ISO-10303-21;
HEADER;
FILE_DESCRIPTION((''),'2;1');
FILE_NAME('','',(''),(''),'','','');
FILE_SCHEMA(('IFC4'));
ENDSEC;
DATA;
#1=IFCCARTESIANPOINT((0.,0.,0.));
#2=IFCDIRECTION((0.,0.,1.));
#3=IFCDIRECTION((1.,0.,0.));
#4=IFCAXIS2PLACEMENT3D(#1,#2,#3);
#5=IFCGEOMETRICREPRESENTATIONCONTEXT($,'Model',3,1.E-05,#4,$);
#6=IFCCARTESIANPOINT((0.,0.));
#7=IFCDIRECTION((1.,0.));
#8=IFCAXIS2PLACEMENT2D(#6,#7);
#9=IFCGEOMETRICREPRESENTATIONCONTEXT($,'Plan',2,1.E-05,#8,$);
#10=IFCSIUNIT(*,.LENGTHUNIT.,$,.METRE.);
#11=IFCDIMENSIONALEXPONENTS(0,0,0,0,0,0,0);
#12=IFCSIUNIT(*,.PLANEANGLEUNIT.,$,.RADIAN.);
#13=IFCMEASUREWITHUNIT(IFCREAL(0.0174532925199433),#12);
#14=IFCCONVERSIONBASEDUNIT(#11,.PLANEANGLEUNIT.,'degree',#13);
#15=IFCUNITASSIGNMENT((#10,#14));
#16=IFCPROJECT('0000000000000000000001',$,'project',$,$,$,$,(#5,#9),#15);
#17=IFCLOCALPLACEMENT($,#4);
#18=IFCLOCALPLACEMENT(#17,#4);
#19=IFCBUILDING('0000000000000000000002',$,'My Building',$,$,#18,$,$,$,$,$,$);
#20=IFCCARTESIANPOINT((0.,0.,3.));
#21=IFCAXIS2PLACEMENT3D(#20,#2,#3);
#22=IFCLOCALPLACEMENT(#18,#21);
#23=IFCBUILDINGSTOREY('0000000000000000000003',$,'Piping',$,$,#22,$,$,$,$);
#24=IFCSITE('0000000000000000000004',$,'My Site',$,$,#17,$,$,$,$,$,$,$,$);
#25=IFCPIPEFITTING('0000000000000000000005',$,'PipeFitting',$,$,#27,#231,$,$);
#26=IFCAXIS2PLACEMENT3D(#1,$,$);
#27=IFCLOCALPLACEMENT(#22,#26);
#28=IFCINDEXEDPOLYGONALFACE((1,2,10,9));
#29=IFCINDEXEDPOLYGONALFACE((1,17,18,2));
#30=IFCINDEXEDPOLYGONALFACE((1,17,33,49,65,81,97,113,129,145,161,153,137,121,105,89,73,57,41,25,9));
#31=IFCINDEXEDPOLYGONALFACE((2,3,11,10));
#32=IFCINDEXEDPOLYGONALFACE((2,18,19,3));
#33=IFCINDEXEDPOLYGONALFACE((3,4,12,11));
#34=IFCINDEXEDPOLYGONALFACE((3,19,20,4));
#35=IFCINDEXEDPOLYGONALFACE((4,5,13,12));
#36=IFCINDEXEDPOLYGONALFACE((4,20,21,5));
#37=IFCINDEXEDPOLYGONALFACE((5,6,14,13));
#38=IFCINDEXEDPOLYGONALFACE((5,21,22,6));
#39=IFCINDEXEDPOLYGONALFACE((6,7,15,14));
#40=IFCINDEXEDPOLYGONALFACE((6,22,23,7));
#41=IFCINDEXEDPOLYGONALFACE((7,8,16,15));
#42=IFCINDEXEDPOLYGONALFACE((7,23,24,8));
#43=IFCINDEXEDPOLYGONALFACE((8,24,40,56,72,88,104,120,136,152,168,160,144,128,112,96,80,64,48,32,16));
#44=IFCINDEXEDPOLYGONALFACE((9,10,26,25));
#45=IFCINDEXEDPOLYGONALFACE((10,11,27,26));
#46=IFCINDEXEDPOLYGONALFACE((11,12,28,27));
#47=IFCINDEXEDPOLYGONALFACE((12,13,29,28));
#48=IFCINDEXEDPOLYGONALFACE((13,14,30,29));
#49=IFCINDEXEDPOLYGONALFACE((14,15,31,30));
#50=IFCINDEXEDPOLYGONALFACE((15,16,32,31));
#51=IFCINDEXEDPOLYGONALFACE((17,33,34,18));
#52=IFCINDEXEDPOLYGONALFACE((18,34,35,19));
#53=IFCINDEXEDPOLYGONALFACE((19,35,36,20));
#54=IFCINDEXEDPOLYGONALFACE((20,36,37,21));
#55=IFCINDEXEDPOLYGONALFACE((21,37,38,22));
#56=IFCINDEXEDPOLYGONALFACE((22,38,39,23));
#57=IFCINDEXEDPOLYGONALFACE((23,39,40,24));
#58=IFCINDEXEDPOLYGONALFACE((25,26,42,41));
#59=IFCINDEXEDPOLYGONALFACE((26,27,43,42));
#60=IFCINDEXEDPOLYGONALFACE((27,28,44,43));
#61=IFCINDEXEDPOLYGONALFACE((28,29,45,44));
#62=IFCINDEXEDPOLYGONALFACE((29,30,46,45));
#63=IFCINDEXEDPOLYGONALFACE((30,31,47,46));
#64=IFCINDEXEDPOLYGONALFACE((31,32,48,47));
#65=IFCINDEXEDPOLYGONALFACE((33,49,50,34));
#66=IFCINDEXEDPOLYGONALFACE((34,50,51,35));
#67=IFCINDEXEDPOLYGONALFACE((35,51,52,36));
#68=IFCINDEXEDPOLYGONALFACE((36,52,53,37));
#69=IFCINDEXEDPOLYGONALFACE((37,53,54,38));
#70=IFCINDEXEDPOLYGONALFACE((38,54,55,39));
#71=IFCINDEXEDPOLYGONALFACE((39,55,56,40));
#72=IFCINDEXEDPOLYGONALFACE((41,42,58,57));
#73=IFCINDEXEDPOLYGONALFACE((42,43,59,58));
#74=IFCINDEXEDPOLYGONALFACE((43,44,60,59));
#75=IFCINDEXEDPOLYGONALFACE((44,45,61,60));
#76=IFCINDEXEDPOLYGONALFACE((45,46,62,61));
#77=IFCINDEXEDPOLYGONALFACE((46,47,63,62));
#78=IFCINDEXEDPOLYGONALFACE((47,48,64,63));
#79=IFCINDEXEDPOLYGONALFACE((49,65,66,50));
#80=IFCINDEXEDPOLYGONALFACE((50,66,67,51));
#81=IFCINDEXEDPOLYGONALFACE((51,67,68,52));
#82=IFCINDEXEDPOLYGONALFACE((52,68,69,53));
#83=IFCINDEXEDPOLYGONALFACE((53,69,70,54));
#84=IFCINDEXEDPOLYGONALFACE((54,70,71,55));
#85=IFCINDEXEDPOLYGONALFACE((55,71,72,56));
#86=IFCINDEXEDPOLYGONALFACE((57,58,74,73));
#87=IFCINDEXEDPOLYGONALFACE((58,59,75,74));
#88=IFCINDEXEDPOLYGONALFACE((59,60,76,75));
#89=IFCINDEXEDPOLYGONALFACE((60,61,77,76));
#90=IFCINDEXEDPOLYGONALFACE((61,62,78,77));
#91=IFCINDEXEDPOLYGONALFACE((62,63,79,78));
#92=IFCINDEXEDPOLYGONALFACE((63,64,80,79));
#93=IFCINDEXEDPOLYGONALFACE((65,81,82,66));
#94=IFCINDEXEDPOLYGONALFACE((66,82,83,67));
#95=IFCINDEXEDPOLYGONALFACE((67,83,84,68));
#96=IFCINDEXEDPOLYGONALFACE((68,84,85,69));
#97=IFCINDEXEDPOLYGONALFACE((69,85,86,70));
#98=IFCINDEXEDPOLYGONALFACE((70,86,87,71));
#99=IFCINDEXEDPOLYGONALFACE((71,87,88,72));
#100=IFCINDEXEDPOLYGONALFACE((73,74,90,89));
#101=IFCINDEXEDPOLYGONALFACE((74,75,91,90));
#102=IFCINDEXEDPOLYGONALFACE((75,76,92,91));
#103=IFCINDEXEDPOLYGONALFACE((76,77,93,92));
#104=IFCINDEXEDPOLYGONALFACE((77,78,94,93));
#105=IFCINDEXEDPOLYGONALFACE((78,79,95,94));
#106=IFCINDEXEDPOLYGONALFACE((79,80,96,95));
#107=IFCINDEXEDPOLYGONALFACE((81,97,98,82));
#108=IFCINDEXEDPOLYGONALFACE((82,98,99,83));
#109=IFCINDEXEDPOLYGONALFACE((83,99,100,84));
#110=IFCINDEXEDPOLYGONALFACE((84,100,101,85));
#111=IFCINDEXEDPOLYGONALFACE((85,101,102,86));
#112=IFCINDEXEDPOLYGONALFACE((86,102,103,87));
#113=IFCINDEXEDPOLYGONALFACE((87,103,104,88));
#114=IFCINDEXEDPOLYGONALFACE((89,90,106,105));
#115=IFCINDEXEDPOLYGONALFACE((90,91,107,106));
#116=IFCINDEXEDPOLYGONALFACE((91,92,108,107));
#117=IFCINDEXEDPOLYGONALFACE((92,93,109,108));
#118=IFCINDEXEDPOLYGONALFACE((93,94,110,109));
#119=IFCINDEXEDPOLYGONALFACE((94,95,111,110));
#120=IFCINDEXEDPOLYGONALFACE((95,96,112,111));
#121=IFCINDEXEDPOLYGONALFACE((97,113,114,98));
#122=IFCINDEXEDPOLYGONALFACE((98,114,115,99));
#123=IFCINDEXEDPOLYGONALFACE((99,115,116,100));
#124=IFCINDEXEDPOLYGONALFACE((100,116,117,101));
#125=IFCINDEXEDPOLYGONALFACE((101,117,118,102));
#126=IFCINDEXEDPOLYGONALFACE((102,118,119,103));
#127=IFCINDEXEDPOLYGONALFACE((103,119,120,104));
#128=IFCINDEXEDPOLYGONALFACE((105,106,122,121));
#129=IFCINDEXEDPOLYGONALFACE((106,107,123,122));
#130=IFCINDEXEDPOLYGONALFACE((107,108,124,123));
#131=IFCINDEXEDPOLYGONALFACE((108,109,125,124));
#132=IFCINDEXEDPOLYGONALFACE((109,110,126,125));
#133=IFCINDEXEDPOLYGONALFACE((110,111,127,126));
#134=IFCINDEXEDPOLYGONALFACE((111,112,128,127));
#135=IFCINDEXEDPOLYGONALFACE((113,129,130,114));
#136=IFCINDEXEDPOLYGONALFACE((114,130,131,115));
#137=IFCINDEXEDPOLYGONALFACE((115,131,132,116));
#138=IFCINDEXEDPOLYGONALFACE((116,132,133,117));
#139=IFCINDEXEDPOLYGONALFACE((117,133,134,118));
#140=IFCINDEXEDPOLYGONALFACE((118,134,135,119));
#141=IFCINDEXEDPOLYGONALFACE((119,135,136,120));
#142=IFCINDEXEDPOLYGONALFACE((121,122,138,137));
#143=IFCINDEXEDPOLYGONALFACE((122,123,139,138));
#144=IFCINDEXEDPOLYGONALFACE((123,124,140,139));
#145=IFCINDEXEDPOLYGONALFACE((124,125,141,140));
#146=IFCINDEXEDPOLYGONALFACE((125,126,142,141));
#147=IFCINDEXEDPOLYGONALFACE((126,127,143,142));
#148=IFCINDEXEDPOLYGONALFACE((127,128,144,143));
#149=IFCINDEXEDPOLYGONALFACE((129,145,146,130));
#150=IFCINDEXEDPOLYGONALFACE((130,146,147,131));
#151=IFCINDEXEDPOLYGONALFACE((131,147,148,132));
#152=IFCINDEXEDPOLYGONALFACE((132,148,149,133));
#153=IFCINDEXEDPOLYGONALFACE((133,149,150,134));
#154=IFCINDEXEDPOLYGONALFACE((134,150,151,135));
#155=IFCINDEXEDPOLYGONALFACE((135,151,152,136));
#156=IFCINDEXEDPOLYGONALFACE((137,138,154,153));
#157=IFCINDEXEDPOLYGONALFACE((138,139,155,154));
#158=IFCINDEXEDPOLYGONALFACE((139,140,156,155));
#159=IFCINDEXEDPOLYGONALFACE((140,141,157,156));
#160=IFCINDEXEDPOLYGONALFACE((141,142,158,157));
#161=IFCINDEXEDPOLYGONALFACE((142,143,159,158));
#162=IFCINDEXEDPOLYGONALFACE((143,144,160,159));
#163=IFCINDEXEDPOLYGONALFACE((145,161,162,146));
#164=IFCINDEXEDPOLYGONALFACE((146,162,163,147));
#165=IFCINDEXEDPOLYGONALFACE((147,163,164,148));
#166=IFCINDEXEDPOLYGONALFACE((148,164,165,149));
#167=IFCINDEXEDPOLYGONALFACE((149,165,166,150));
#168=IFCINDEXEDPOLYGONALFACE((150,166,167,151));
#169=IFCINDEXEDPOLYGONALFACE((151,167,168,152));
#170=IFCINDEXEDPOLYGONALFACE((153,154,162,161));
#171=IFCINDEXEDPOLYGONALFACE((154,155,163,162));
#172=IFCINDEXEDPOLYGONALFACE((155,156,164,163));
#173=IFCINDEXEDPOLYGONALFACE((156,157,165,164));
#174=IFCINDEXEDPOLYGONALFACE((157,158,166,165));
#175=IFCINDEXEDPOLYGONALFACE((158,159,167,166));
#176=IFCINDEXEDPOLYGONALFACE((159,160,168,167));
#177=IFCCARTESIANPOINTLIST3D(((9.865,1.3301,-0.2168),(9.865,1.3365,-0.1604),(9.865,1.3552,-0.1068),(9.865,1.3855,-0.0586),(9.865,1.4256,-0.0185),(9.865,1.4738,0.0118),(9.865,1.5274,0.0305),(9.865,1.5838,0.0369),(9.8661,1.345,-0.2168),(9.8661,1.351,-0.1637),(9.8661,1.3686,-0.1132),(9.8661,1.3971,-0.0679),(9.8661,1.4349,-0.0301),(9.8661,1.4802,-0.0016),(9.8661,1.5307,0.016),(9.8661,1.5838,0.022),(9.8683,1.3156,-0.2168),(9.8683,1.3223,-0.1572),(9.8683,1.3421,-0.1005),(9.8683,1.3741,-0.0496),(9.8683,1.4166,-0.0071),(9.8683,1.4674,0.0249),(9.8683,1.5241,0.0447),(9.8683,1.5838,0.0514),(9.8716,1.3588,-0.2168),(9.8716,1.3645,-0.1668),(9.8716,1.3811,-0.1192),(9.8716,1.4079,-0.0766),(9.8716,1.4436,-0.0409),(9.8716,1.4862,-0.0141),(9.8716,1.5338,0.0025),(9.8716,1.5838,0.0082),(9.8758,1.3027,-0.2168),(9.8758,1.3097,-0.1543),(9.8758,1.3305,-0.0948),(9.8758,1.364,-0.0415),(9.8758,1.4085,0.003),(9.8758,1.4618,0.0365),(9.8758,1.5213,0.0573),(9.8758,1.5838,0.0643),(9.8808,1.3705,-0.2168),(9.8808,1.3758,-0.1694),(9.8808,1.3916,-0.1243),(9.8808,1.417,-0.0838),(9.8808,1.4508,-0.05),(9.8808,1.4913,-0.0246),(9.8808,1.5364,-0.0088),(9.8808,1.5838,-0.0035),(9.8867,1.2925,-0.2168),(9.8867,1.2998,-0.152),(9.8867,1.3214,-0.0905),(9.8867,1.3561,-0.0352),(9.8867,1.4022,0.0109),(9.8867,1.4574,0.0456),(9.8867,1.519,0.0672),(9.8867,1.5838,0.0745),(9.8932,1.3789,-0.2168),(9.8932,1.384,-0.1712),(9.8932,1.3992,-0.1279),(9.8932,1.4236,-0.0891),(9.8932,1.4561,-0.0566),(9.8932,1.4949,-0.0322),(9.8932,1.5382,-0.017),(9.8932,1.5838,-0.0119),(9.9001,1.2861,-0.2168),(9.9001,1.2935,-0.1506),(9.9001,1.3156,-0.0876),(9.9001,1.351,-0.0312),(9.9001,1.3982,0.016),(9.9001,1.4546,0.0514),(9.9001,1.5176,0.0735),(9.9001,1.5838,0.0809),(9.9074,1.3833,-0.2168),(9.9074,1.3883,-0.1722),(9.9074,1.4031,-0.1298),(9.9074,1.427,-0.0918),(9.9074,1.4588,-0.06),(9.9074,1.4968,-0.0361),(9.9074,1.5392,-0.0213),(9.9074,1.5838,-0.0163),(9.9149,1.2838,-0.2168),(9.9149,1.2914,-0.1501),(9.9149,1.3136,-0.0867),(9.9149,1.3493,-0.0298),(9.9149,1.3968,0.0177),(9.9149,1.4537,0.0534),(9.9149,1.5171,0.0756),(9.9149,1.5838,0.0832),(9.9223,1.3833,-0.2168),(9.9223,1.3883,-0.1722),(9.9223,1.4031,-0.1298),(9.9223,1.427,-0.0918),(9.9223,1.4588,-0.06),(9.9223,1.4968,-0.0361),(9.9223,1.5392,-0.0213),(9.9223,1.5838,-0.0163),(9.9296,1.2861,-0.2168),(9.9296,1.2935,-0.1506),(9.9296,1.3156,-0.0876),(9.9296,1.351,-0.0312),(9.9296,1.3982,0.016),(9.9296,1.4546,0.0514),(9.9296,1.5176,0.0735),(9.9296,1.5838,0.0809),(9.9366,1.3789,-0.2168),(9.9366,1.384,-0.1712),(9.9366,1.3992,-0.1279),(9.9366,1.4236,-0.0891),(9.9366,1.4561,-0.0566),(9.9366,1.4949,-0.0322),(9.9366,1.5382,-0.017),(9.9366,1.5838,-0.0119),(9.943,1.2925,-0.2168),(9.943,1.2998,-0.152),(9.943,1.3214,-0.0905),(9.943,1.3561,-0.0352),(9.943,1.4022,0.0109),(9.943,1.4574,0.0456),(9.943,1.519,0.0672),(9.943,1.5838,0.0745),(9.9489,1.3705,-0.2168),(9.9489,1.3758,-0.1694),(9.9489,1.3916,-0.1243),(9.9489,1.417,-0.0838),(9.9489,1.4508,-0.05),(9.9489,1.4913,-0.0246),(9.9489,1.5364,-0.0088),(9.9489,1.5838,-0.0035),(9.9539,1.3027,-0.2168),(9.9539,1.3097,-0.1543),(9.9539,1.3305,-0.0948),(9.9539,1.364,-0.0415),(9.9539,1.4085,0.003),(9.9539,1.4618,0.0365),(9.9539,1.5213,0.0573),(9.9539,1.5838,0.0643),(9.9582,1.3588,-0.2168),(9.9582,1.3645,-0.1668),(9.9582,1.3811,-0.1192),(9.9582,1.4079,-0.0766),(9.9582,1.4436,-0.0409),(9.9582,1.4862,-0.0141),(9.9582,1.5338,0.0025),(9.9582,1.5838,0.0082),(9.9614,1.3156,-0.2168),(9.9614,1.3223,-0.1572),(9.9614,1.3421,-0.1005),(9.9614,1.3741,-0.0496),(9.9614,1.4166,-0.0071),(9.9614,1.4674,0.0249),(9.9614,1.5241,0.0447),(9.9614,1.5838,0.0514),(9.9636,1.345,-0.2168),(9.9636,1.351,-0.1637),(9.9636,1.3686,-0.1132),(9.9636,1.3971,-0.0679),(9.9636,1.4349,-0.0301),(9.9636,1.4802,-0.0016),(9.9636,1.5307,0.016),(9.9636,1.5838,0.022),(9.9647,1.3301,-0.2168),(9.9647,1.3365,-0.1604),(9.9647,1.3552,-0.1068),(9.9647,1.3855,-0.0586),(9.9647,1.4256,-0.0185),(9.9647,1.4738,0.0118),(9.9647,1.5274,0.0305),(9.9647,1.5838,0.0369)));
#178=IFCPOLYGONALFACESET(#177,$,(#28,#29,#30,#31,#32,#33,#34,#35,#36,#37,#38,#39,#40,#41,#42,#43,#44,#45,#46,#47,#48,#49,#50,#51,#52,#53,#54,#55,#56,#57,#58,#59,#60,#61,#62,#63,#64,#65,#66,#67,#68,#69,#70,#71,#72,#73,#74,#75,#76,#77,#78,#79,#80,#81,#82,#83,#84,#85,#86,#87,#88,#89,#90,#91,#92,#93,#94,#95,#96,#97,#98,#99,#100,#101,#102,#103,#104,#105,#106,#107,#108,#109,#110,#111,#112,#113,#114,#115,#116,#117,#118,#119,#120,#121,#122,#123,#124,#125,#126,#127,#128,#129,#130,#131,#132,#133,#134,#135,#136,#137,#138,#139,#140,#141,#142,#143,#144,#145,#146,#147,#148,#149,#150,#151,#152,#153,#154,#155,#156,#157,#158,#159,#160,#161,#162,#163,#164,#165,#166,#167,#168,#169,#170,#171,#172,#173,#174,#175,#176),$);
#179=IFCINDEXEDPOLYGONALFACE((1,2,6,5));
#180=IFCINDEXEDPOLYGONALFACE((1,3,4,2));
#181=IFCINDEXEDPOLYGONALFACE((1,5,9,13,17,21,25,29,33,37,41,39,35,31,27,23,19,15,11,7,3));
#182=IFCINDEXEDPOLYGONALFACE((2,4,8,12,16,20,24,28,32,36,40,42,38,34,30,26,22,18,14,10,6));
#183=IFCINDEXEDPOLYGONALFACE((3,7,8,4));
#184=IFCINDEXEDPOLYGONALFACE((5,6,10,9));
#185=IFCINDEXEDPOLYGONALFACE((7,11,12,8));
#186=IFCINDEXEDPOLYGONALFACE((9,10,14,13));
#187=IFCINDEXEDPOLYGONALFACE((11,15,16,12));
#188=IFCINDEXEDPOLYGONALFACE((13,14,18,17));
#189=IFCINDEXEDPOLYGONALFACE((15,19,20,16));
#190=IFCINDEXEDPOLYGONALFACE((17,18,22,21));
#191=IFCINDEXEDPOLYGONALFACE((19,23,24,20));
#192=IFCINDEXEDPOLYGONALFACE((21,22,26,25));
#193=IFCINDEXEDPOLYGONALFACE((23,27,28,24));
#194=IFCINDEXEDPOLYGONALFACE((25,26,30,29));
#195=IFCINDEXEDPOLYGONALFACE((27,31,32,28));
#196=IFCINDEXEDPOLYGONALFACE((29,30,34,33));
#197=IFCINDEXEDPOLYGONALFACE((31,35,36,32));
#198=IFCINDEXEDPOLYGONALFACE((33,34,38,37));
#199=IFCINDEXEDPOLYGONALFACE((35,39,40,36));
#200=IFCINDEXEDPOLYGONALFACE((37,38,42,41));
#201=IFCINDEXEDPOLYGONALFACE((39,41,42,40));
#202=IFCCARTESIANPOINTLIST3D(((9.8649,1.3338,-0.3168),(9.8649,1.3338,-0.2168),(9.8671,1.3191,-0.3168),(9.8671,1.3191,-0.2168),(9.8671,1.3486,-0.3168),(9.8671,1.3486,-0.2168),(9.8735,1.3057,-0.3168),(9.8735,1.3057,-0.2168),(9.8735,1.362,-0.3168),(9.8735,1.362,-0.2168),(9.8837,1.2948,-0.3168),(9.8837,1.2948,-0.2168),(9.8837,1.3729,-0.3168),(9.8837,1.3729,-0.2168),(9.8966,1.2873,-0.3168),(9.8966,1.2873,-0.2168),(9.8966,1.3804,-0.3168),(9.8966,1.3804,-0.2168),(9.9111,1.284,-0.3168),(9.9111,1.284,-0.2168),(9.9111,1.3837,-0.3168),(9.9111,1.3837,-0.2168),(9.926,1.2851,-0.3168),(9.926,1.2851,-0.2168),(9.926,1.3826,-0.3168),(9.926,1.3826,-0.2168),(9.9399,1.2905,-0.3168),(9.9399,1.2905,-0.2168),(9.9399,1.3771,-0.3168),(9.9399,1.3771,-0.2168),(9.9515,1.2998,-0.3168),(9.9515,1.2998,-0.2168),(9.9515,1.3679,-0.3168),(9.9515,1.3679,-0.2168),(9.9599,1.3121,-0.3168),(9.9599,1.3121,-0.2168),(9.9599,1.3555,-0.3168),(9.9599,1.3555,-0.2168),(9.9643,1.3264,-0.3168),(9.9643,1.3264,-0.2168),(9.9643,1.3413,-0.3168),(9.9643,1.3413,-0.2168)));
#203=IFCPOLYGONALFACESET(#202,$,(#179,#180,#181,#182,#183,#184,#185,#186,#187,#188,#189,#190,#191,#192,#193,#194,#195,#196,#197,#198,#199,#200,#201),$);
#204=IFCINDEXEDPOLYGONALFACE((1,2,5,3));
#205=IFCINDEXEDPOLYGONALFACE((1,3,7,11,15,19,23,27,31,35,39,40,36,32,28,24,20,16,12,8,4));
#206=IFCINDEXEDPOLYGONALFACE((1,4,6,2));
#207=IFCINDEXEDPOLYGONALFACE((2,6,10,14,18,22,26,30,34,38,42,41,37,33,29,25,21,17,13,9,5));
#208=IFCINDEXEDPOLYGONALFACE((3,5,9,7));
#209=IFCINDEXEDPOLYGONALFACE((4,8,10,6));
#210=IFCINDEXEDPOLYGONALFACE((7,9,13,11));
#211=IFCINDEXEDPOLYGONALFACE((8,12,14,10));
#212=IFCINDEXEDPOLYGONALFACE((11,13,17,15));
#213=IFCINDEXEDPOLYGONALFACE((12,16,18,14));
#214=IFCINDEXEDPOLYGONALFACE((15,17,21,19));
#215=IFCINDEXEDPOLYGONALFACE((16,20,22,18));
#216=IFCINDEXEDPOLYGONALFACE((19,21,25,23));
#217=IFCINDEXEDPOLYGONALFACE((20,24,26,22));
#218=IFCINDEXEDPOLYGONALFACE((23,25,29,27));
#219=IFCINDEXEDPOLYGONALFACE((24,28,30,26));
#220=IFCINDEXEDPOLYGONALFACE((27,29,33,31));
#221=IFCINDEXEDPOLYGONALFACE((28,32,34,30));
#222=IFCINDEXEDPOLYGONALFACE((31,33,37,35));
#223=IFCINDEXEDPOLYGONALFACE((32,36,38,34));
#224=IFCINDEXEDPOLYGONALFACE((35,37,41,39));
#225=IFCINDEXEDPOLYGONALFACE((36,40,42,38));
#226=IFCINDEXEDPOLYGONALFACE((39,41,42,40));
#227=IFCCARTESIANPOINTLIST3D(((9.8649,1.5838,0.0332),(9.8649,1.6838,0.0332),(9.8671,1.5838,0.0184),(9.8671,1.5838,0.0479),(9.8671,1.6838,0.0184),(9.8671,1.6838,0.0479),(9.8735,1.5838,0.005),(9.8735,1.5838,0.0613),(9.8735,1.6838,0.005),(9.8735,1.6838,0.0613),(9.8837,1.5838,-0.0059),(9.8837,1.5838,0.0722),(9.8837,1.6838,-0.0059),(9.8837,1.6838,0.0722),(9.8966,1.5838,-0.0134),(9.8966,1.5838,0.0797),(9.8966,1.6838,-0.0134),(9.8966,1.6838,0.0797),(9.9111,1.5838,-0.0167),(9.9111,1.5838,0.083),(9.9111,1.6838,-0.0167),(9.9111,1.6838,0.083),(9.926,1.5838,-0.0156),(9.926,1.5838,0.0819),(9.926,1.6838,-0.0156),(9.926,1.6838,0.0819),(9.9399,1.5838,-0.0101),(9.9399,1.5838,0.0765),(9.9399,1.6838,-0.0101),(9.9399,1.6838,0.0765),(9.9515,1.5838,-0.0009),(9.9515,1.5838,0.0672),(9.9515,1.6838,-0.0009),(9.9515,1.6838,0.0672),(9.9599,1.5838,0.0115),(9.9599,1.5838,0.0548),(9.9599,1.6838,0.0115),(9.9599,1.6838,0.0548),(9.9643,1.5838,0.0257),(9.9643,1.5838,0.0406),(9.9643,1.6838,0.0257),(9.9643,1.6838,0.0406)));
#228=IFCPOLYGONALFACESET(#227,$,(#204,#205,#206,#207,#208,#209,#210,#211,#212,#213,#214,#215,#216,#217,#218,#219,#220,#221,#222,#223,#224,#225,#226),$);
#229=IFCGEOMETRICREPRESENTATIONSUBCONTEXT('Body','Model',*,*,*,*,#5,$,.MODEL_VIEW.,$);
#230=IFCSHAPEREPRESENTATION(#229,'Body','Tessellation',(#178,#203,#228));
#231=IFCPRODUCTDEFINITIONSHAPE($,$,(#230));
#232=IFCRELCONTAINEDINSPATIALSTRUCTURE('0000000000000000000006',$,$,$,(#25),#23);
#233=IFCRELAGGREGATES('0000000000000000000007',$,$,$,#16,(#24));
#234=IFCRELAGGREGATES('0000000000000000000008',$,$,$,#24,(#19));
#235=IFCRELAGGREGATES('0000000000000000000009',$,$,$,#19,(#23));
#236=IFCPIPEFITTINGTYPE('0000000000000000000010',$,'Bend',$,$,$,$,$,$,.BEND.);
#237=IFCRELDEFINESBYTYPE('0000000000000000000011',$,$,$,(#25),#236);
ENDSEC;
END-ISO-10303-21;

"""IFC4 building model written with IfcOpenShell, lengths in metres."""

from ifc_helpers import new_model, entity, si_unit, converted_unit, frame, origin_with_axes, origin_2d_with_axis, place, context, subcontext, project, spatial, circle, extrude, source, transform, mapped, type_object, type_shapes, element, save


model = new_model("IFC4")

# Units and contexts
model_context = context("Model", 3, precision=1e-05, world=origin_with_axes())
plan_context = context("Plan", 2, precision=1e-05, world=origin_2d_with_axis())
body_context = subcontext(model_context, "Body", "Model", "MODEL_VIEW")
ifc_project = project(units=[si_unit("LENGTHUNIT", "METRE"), converted_unit("PLANEANGLEUNIT", "degree", entity("IfcReal", 0.0174532925199433), si_unit("PLANEANGLEUNIT", "RADIAN"), dimensions=[0, 0, 0, 0, 0, 0, 0])], contexts=[model_context, plan_context])

# Site, building, storey
site_placement = place(None, origin_with_axes())
site = spatial("IfcSite", under=ifc_project, at=site_placement, Name="My Site")
building_placement = place(site_placement, origin_with_axes())
building = spatial("IfcBuilding", under=site, at=building_placement, Name="My Building")
storey_placement = place(building_placement, frame((0.0, 0.0, 3.0), z_axis=(0.0, 0.0, 1.0), x_axis=(1.0, 0.0, 0.0)))
storey = spatial("IfcBuildingStorey", under=building, at=storey_placement, Name="Piping")

# Pipe fitting
pipe_fitting_type = type_object("IfcPipeFittingType", Name="Bend", PredefinedType="BEND")
shared_shape = source(origin_with_axes(), body_context, "Body", "SolidModel", [
    entity("IfcSweptDiskSolid", entity("IfcIndexedPolyCurve", entity("IfcCartesianPointList3D", [[0.0, 0.0, -0.1], [0.0, 0.0732, -0.2768], [0.0, 0.25, -0.35]]), [entity("IfcArcIndex", [1, 2, 3])]), 0.05),
    extrude(circle(Radius=0.05), origin_with_axes(), (0.0, 0.0, -1.0), 0.1),
    extrude(circle(Radius=0.05), frame((0.0, 0.25, -0.35), z_axis=(0.0, 1.0, 0.0), x_axis=(1.0, 0.0, 0.0)), (0.0, 0.0, 1.0), 0.1),
])
type_shapes(pipe_fitting_type, [shared_shape])
for number, where, z_axis, x_axis, name in (
    (1, (9.9149, 1.3338, -0.3168), (0.0, 0.0, -1.0), (-1.0, 0.0, 0.0), "PipeFitting"),
):
    element("IfcPipeFitting", number, at=place(storey_placement, frame(where, z_axis=z_axis, x_axis=x_axis)), inside=storey, type_object=pipe_fitting_type, Name=name, context=body_context, shape_type="MappedRepresentation", body=[
        mapped(shared_shape, transform((0.0, 0.0, 0.0), x_axis=(1.0, 0.0, 0.0), y_axis=(0.0, 1.0, 0.0), z_axis=(0.0, 0.0, 1.0), scale=1.0)),
    ])

save(model, "model.ifc")
